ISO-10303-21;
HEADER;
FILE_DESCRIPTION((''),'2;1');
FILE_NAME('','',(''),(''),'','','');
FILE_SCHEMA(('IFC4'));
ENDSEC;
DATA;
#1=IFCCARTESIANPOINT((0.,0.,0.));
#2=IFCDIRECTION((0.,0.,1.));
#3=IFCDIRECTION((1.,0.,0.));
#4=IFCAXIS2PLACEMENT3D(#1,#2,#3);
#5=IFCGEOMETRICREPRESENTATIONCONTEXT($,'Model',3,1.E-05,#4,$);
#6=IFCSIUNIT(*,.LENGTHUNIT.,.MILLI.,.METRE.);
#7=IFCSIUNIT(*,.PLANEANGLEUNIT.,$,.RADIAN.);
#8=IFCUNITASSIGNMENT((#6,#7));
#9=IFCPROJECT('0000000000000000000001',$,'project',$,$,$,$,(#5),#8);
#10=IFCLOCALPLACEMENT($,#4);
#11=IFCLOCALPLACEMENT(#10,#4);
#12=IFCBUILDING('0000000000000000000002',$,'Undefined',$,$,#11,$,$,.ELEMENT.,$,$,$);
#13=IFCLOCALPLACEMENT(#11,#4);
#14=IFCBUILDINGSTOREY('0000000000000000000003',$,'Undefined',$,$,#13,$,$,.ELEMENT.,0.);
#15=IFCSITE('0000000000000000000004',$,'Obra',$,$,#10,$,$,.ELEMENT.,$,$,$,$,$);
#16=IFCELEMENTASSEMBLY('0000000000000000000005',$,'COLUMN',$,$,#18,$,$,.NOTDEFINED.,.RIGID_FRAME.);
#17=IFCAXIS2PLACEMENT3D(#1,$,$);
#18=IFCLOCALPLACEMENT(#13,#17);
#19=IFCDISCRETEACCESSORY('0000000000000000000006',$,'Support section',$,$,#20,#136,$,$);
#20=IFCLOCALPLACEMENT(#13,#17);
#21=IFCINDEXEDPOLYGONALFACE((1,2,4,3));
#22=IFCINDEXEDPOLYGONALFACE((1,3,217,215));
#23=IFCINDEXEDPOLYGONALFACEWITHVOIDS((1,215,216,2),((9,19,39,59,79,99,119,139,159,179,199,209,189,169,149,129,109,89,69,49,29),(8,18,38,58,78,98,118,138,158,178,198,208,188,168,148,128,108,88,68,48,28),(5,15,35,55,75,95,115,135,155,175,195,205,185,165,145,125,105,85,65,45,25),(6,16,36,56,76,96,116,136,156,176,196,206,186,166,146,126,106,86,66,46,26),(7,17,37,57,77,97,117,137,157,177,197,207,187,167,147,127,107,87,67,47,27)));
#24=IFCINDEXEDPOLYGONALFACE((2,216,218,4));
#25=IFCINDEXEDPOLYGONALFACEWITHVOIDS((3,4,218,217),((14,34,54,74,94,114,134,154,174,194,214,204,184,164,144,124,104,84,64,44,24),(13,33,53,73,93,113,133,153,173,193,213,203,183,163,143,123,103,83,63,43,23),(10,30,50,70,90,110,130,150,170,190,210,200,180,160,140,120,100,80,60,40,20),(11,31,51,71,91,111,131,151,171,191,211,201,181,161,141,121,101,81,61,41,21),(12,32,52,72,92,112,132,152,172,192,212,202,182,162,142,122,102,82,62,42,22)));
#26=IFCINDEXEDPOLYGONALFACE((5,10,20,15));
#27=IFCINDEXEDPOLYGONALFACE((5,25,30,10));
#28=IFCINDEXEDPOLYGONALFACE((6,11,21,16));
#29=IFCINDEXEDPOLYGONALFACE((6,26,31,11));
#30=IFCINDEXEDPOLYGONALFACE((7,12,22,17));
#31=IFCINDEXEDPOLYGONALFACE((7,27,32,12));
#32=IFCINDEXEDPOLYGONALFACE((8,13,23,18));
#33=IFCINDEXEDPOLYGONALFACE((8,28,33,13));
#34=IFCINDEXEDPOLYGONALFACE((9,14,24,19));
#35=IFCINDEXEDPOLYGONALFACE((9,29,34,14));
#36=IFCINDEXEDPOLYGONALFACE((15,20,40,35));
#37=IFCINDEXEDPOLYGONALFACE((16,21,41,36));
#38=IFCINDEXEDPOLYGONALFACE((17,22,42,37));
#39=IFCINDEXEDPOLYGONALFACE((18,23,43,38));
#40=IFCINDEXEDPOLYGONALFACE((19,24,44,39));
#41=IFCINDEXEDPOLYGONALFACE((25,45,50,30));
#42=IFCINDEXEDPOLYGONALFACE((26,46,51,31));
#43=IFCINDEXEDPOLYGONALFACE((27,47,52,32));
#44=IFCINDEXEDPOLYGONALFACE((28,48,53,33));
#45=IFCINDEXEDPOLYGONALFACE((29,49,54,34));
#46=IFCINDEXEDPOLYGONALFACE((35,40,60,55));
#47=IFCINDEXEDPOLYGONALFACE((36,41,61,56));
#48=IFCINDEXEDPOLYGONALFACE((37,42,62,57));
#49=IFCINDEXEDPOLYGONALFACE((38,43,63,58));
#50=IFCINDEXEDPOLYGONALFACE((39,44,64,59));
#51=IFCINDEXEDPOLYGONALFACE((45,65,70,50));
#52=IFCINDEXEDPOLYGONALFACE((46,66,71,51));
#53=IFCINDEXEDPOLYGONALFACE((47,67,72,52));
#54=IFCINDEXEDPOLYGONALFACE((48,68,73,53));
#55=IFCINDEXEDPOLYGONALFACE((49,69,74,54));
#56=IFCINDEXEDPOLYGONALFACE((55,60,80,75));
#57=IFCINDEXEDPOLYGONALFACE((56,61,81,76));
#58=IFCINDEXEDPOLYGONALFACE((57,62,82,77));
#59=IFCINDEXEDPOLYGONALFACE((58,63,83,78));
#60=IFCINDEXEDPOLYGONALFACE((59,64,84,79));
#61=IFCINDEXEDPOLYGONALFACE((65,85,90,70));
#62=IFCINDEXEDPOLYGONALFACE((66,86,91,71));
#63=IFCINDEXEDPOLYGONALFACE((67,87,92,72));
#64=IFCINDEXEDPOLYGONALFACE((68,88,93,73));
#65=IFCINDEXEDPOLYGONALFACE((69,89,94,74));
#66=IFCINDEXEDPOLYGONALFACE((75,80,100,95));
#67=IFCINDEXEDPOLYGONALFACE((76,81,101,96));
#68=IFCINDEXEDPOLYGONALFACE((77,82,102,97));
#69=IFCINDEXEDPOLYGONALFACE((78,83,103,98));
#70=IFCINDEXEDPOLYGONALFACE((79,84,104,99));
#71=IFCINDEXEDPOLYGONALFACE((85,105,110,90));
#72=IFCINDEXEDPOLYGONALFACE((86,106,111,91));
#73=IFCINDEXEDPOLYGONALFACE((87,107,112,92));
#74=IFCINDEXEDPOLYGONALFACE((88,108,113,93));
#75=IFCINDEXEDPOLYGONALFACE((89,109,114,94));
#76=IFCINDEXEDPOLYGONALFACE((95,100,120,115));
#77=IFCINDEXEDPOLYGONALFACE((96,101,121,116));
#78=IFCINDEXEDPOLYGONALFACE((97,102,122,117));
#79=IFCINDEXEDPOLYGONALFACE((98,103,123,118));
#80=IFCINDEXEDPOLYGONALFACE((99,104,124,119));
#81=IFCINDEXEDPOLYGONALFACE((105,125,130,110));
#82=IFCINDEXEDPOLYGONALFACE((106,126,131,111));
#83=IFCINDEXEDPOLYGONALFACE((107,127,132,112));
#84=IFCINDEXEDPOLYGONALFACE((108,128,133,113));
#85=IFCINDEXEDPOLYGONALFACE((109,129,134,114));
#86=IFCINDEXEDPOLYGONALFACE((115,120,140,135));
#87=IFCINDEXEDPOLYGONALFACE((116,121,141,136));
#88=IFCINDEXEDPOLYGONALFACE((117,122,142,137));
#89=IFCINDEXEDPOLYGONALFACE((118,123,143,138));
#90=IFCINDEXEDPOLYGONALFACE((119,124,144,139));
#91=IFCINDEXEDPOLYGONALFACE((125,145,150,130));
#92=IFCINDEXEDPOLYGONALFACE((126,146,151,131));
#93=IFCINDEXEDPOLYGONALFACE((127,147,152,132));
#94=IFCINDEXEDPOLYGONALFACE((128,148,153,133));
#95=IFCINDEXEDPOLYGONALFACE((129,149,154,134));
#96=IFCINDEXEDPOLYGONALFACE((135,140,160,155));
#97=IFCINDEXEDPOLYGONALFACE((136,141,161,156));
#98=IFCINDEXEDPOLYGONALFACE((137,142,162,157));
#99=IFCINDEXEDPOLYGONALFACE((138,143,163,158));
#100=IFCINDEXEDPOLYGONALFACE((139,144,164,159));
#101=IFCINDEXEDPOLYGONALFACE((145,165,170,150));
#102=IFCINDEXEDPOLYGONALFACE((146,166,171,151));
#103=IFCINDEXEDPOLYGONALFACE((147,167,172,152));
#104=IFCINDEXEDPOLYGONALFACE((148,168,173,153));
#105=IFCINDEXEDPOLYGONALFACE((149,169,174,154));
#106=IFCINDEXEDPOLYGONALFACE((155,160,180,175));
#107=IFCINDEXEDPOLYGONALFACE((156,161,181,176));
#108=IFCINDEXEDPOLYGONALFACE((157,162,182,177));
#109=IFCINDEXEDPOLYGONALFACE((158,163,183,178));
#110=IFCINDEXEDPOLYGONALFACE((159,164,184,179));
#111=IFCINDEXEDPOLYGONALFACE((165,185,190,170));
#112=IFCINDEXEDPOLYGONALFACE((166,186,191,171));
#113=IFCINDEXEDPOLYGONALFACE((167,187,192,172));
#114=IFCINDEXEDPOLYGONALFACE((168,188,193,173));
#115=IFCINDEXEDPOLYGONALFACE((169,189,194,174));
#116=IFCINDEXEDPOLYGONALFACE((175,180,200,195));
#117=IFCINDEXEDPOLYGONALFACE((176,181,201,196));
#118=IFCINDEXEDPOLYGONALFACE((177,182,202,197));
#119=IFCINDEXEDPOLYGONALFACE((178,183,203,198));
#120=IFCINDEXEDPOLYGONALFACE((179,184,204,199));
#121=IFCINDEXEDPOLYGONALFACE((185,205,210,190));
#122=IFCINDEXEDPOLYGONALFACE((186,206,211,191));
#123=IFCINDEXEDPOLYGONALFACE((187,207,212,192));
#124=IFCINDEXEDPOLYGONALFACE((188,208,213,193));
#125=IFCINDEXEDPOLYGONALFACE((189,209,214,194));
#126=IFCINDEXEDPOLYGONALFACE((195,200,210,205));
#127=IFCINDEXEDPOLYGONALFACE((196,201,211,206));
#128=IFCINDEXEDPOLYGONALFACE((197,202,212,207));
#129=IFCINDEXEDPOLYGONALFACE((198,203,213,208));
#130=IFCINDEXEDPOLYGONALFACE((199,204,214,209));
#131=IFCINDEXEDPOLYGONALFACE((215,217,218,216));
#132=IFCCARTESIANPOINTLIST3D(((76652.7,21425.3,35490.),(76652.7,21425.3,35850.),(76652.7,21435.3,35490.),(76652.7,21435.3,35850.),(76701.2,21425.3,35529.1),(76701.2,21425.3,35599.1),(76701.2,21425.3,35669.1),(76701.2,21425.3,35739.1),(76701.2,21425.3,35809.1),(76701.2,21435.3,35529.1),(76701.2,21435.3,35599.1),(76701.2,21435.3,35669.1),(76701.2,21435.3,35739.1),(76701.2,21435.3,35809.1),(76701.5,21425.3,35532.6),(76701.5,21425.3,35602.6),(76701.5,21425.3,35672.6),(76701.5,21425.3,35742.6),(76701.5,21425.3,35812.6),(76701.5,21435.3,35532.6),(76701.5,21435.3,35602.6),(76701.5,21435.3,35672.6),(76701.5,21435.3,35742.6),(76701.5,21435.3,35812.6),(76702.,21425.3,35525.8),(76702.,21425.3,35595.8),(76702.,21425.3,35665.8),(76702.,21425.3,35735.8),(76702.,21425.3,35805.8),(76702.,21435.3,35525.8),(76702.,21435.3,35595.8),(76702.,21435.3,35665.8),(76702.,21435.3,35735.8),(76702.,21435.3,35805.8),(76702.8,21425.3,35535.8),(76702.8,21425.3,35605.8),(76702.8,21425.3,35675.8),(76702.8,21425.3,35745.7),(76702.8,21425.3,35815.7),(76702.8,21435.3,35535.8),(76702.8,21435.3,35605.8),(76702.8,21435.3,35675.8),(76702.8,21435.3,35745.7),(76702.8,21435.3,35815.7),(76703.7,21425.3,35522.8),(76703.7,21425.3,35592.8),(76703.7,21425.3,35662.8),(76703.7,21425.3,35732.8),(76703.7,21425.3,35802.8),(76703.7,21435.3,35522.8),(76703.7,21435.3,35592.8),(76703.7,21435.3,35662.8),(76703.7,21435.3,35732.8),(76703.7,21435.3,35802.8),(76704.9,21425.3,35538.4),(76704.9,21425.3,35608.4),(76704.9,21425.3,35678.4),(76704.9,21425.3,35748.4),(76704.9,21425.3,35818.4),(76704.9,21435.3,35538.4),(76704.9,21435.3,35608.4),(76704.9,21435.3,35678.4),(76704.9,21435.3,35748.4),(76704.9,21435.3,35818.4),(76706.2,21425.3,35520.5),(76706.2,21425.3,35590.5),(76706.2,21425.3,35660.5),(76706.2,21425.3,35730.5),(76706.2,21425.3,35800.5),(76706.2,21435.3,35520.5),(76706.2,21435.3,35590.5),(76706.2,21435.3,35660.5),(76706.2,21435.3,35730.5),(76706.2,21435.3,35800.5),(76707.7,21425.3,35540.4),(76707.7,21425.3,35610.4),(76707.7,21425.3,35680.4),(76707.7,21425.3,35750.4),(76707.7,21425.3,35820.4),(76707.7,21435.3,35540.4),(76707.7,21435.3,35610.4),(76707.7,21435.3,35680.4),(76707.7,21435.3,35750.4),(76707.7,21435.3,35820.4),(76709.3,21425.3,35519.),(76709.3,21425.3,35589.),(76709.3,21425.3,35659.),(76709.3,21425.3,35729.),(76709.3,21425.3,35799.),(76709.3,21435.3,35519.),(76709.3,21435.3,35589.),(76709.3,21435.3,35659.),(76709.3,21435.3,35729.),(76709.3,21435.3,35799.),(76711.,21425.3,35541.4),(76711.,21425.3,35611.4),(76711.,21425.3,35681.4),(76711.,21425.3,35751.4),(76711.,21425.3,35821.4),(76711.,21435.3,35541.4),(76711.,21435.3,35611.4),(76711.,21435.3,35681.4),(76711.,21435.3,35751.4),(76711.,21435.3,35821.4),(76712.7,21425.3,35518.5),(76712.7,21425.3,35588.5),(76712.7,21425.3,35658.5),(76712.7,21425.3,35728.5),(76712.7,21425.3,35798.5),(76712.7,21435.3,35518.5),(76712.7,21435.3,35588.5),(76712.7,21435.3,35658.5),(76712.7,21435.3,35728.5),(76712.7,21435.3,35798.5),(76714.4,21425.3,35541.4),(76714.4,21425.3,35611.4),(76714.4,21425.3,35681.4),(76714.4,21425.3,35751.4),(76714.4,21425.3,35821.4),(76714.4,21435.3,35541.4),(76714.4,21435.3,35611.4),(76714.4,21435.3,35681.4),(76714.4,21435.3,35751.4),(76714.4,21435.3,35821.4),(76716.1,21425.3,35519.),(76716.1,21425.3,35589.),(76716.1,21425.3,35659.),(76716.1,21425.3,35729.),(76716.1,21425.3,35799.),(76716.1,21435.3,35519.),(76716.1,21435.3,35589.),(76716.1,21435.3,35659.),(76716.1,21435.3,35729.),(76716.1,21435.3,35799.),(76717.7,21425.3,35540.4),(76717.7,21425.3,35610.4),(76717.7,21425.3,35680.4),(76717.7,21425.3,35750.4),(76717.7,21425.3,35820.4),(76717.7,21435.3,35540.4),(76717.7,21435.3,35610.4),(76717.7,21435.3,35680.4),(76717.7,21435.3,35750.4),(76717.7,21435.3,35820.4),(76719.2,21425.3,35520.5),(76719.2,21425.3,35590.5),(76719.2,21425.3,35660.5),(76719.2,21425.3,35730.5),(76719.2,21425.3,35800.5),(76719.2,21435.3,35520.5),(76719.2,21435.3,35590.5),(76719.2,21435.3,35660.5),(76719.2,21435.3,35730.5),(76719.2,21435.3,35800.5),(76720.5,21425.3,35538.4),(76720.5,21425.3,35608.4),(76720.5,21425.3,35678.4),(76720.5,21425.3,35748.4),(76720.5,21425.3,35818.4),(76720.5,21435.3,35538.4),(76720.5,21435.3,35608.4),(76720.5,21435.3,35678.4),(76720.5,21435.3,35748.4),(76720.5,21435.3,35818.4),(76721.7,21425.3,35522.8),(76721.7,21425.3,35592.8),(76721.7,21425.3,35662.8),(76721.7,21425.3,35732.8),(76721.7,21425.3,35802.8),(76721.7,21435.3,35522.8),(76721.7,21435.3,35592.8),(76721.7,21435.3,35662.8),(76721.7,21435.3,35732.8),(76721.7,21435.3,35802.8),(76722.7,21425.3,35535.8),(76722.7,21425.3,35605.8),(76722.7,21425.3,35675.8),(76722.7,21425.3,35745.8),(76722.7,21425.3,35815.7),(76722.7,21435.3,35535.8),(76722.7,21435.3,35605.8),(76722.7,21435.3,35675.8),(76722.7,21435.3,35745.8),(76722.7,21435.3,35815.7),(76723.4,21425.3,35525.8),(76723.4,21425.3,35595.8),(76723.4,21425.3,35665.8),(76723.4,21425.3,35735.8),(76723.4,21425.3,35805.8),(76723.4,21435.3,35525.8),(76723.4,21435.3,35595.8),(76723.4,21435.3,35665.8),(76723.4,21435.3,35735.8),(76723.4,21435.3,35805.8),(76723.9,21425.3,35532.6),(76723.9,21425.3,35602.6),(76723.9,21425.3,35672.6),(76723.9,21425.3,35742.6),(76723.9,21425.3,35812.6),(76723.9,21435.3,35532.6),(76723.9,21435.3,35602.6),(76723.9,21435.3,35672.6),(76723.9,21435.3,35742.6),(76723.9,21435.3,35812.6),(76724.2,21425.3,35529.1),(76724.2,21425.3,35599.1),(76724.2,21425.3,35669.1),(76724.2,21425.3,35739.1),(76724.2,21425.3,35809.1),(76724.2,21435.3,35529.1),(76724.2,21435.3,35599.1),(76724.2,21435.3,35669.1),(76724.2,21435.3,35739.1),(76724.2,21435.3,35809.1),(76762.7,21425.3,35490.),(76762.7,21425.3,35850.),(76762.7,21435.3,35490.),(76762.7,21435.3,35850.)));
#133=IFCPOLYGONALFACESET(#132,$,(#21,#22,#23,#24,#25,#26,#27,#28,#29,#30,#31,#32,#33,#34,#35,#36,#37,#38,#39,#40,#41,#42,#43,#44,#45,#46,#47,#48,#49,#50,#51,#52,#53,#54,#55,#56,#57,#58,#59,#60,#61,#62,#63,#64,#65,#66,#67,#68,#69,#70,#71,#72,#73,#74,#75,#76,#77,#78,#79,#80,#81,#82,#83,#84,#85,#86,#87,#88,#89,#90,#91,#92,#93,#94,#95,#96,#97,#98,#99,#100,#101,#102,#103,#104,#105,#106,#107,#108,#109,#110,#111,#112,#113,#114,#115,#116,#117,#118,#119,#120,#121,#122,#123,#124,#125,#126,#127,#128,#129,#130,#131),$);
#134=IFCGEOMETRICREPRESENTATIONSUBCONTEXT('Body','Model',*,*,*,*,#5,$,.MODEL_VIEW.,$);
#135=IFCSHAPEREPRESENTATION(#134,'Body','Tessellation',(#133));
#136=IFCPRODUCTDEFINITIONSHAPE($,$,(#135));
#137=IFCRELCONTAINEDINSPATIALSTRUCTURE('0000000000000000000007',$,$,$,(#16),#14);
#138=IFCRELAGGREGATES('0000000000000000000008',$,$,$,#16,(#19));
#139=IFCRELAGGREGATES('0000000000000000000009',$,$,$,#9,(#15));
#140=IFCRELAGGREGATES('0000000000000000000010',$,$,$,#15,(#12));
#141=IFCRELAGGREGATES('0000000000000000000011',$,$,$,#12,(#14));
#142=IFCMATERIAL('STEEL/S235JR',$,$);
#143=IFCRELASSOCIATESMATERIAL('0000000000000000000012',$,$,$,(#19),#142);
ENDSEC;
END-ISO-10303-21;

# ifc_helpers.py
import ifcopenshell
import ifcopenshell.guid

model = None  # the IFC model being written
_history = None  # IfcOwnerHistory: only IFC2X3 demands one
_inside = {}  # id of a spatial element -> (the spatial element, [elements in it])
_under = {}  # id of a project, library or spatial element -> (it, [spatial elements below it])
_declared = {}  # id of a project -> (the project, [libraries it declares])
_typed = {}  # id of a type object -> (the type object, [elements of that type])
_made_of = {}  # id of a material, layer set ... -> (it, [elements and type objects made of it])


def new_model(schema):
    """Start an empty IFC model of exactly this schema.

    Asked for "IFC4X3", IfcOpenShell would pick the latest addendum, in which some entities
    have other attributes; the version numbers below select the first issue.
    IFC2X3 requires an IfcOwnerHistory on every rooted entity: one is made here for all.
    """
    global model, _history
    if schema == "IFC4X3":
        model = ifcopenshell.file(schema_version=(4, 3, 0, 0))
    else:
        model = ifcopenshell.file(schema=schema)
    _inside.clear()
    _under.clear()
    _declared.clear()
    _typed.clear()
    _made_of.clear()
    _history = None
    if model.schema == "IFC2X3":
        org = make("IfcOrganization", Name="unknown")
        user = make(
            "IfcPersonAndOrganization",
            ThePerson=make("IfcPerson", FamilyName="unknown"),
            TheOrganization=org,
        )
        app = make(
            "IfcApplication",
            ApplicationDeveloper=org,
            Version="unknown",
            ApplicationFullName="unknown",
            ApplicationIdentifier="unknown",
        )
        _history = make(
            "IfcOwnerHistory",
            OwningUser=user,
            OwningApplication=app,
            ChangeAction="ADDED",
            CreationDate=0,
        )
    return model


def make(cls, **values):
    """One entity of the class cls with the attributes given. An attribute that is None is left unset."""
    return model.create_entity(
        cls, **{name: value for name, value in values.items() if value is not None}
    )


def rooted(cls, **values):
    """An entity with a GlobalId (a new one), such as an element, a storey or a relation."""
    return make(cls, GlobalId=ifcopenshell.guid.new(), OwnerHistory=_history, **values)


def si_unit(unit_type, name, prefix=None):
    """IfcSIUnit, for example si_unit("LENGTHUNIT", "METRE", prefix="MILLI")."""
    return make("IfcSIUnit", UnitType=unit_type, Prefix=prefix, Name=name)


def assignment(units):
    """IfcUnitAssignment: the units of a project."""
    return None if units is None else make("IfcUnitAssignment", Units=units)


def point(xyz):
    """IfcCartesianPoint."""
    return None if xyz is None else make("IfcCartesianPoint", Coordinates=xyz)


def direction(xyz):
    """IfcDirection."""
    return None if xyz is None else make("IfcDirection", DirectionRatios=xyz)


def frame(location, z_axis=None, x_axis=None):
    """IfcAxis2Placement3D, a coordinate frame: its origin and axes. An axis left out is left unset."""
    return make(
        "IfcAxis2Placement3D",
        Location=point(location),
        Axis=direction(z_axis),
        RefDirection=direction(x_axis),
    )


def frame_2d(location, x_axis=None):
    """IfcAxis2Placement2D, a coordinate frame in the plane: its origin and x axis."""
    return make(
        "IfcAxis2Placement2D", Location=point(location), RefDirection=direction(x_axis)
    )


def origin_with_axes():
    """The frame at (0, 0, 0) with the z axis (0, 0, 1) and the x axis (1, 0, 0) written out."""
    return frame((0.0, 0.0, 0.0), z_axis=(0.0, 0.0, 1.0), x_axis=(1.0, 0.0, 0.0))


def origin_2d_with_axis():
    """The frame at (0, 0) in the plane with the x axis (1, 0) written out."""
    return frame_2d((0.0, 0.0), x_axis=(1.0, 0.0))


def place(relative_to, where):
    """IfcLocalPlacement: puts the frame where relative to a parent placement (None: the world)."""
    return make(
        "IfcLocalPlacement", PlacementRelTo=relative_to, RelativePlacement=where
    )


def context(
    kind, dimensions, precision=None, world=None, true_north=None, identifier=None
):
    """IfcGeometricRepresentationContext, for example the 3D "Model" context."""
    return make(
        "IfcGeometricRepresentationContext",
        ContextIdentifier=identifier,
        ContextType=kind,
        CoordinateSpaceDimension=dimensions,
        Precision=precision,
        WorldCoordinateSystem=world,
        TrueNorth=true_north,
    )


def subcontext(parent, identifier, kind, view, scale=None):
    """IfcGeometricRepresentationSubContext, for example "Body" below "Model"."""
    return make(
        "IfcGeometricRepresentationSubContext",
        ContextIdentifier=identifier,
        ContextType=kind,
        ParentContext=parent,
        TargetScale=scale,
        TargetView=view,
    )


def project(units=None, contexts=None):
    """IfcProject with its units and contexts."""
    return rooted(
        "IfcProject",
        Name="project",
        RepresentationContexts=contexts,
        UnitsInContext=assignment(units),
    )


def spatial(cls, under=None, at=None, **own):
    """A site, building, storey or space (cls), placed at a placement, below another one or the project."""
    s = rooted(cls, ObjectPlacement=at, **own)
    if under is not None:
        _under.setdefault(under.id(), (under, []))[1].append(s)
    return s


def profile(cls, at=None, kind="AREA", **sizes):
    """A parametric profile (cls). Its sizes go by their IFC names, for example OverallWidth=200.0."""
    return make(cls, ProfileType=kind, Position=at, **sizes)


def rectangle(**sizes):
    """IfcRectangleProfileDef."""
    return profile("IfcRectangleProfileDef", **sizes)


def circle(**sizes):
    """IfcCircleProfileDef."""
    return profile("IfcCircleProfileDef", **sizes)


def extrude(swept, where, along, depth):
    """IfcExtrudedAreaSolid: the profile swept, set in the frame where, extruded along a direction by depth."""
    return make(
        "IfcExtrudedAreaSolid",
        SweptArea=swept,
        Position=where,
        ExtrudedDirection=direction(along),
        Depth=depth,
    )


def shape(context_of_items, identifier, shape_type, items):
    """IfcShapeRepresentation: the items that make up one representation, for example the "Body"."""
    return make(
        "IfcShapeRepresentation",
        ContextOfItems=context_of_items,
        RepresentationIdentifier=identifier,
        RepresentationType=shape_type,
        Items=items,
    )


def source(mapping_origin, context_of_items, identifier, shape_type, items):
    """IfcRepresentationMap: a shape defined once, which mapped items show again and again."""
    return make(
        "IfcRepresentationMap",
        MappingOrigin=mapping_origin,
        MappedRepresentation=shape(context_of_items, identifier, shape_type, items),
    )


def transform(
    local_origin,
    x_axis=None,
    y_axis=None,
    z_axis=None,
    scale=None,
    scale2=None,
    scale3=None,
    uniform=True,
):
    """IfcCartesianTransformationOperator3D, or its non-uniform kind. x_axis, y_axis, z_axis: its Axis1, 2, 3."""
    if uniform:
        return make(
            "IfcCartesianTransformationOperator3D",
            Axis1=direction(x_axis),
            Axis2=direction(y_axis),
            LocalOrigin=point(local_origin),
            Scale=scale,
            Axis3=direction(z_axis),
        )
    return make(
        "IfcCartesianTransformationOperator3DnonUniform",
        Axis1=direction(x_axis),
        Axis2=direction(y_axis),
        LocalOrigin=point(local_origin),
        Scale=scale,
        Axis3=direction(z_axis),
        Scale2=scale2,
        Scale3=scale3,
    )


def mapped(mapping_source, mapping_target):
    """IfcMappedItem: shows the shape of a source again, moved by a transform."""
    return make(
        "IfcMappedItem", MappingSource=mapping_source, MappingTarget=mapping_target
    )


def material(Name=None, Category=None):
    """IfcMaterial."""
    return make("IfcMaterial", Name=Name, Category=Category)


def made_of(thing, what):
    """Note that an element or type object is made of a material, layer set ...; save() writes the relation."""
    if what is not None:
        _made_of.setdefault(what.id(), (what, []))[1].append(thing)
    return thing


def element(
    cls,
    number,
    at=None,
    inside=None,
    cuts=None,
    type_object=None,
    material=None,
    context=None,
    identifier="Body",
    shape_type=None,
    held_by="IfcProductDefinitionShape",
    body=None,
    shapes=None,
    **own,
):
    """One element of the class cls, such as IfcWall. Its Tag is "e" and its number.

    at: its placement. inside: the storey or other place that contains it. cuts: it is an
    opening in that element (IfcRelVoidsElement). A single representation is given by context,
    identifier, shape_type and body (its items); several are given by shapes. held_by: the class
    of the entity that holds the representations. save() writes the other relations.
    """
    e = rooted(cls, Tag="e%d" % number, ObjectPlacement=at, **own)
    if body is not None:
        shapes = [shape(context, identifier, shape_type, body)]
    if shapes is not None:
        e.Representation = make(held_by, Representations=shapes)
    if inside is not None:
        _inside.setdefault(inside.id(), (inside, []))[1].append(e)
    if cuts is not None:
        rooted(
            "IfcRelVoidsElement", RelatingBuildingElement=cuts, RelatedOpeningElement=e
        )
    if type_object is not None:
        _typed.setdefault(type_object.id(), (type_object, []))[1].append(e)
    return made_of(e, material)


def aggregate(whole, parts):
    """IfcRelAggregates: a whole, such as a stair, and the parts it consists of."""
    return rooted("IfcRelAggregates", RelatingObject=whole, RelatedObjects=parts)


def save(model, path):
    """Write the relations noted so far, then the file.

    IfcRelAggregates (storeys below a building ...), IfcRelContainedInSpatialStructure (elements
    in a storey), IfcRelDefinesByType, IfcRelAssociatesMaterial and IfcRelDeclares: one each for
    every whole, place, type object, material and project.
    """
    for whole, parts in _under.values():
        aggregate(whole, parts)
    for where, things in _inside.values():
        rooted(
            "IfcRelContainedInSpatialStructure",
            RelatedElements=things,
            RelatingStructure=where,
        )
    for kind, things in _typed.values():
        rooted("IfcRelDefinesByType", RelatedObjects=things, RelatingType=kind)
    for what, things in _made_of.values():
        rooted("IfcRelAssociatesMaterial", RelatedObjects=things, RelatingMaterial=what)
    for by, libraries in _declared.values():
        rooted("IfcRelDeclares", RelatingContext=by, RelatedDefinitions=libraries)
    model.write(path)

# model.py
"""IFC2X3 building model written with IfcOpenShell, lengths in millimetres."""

from ifc_helpers import new_model, si_unit, frame, origin_with_axes, origin_2d_with_axis, place, context, subcontext, project, spatial, rectangle, circle, extrude, source, transform, mapped, material, element, aggregate, save


model = new_model("IFC2X3")

# Units and contexts
model_context = context("Model", 3, precision=1e-05, world=origin_with_axes())
body_context = subcontext(model_context, "Body", "Model", "MODEL_VIEW")
ifc_project = project(units=[si_unit("LENGTHUNIT", "METRE", prefix="MILLI"), si_unit("PLANEANGLEUNIT", "RADIAN")], contexts=[model_context])

# Site, building, storey
site_placement = place(None, origin_with_axes())
site = spatial("IfcSite", under=ifc_project, at=site_placement, Name="Obra", CompositionType="ELEMENT")
building_placement = place(site_placement, origin_with_axes())
building = spatial("IfcBuilding", under=site, at=building_placement, Name="Undefined", CompositionType="ELEMENT")
storey_placement = place(building_placement, origin_with_axes())
storey = spatial("IfcBuildingStorey", under=building, at=storey_placement, Name="Undefined", CompositionType="ELEMENT", Elevation=0.0)

# Shared definitions
ifc_material_1 = material(Name="STEEL/S235JR")

# Element assembly, discrete accessory, opening
assembly_1_placement = place(storey_placement, origin_with_axes())
assembly_1 = element("IfcElementAssembly", 1, at=assembly_1_placement, inside=storey, Name="COLUMN", AssemblyPlace="NOTDEFINED", PredefinedType="RIGID_FRAME")
discrete_accessory_1_placement = place(assembly_1_placement, frame((76707.7, 21430.3, 35490.0), z_axis=(0.0, 0.0, 1.0), x_axis=(-1.0, 0.0, 0.0)))
discrete_accessory_1 = element("IfcDiscreteAccessory", 2, at=discrete_accessory_1_placement, material=ifc_material_1, Name="Support section", context=body_context, shape_type="SweptSolid", body=[
    extrude(rectangle(XDim=10.0, YDim=110.0, at=origin_2d_with_axis()), frame((0.0, 0.0, 360.0), z_axis=(0.0, 0.0, -1.0), x_axis=(0.0, 1.0, 0.0)), (0.0, 0.0, 1.0), 360.0),
])
shared_shape_1 = source(origin_with_axes(), body_context, "Body", "SweptSolid", [
    extrude(circle(Radius=11.5, at=origin_2d_with_axis()), frame((0.0, -14.4, 0.0), z_axis=(0.0, 1.0, 0.0), x_axis=(1.0, 0.0, 0.0)), (0.0, 0.0, 1.0), 10.2),
])
opening_1_placement = place(assembly_1_placement, frame((76662.7, 21439.6, 35870.0), z_axis=(1.0, 0.0, 0.0), x_axis=(0.0, 0.0, -1.0)))
element("IfcOpeningElement", 3, at=opening_1_placement, cuts=discrete_accessory_1, ObjectType="Opening", context=body_context, shape_type="MappedRepresentation", body=[
    mapped(shared_shape_1, transform((60.0, 0.0, 50.0))),
    mapped(shared_shape_1, transform((130.0, 0.0, 50.0))),
    mapped(shared_shape_1, transform((200.0, 0.0, 50.0))),
    mapped(shared_shape_1, transform((270.0, 0.0, 50.0))),
    mapped(shared_shape_1, transform((340.0, 0.0, 50.0))),
])
aggregate(assembly_1, [discrete_accessory_1])

save(model, "model.ifc")
